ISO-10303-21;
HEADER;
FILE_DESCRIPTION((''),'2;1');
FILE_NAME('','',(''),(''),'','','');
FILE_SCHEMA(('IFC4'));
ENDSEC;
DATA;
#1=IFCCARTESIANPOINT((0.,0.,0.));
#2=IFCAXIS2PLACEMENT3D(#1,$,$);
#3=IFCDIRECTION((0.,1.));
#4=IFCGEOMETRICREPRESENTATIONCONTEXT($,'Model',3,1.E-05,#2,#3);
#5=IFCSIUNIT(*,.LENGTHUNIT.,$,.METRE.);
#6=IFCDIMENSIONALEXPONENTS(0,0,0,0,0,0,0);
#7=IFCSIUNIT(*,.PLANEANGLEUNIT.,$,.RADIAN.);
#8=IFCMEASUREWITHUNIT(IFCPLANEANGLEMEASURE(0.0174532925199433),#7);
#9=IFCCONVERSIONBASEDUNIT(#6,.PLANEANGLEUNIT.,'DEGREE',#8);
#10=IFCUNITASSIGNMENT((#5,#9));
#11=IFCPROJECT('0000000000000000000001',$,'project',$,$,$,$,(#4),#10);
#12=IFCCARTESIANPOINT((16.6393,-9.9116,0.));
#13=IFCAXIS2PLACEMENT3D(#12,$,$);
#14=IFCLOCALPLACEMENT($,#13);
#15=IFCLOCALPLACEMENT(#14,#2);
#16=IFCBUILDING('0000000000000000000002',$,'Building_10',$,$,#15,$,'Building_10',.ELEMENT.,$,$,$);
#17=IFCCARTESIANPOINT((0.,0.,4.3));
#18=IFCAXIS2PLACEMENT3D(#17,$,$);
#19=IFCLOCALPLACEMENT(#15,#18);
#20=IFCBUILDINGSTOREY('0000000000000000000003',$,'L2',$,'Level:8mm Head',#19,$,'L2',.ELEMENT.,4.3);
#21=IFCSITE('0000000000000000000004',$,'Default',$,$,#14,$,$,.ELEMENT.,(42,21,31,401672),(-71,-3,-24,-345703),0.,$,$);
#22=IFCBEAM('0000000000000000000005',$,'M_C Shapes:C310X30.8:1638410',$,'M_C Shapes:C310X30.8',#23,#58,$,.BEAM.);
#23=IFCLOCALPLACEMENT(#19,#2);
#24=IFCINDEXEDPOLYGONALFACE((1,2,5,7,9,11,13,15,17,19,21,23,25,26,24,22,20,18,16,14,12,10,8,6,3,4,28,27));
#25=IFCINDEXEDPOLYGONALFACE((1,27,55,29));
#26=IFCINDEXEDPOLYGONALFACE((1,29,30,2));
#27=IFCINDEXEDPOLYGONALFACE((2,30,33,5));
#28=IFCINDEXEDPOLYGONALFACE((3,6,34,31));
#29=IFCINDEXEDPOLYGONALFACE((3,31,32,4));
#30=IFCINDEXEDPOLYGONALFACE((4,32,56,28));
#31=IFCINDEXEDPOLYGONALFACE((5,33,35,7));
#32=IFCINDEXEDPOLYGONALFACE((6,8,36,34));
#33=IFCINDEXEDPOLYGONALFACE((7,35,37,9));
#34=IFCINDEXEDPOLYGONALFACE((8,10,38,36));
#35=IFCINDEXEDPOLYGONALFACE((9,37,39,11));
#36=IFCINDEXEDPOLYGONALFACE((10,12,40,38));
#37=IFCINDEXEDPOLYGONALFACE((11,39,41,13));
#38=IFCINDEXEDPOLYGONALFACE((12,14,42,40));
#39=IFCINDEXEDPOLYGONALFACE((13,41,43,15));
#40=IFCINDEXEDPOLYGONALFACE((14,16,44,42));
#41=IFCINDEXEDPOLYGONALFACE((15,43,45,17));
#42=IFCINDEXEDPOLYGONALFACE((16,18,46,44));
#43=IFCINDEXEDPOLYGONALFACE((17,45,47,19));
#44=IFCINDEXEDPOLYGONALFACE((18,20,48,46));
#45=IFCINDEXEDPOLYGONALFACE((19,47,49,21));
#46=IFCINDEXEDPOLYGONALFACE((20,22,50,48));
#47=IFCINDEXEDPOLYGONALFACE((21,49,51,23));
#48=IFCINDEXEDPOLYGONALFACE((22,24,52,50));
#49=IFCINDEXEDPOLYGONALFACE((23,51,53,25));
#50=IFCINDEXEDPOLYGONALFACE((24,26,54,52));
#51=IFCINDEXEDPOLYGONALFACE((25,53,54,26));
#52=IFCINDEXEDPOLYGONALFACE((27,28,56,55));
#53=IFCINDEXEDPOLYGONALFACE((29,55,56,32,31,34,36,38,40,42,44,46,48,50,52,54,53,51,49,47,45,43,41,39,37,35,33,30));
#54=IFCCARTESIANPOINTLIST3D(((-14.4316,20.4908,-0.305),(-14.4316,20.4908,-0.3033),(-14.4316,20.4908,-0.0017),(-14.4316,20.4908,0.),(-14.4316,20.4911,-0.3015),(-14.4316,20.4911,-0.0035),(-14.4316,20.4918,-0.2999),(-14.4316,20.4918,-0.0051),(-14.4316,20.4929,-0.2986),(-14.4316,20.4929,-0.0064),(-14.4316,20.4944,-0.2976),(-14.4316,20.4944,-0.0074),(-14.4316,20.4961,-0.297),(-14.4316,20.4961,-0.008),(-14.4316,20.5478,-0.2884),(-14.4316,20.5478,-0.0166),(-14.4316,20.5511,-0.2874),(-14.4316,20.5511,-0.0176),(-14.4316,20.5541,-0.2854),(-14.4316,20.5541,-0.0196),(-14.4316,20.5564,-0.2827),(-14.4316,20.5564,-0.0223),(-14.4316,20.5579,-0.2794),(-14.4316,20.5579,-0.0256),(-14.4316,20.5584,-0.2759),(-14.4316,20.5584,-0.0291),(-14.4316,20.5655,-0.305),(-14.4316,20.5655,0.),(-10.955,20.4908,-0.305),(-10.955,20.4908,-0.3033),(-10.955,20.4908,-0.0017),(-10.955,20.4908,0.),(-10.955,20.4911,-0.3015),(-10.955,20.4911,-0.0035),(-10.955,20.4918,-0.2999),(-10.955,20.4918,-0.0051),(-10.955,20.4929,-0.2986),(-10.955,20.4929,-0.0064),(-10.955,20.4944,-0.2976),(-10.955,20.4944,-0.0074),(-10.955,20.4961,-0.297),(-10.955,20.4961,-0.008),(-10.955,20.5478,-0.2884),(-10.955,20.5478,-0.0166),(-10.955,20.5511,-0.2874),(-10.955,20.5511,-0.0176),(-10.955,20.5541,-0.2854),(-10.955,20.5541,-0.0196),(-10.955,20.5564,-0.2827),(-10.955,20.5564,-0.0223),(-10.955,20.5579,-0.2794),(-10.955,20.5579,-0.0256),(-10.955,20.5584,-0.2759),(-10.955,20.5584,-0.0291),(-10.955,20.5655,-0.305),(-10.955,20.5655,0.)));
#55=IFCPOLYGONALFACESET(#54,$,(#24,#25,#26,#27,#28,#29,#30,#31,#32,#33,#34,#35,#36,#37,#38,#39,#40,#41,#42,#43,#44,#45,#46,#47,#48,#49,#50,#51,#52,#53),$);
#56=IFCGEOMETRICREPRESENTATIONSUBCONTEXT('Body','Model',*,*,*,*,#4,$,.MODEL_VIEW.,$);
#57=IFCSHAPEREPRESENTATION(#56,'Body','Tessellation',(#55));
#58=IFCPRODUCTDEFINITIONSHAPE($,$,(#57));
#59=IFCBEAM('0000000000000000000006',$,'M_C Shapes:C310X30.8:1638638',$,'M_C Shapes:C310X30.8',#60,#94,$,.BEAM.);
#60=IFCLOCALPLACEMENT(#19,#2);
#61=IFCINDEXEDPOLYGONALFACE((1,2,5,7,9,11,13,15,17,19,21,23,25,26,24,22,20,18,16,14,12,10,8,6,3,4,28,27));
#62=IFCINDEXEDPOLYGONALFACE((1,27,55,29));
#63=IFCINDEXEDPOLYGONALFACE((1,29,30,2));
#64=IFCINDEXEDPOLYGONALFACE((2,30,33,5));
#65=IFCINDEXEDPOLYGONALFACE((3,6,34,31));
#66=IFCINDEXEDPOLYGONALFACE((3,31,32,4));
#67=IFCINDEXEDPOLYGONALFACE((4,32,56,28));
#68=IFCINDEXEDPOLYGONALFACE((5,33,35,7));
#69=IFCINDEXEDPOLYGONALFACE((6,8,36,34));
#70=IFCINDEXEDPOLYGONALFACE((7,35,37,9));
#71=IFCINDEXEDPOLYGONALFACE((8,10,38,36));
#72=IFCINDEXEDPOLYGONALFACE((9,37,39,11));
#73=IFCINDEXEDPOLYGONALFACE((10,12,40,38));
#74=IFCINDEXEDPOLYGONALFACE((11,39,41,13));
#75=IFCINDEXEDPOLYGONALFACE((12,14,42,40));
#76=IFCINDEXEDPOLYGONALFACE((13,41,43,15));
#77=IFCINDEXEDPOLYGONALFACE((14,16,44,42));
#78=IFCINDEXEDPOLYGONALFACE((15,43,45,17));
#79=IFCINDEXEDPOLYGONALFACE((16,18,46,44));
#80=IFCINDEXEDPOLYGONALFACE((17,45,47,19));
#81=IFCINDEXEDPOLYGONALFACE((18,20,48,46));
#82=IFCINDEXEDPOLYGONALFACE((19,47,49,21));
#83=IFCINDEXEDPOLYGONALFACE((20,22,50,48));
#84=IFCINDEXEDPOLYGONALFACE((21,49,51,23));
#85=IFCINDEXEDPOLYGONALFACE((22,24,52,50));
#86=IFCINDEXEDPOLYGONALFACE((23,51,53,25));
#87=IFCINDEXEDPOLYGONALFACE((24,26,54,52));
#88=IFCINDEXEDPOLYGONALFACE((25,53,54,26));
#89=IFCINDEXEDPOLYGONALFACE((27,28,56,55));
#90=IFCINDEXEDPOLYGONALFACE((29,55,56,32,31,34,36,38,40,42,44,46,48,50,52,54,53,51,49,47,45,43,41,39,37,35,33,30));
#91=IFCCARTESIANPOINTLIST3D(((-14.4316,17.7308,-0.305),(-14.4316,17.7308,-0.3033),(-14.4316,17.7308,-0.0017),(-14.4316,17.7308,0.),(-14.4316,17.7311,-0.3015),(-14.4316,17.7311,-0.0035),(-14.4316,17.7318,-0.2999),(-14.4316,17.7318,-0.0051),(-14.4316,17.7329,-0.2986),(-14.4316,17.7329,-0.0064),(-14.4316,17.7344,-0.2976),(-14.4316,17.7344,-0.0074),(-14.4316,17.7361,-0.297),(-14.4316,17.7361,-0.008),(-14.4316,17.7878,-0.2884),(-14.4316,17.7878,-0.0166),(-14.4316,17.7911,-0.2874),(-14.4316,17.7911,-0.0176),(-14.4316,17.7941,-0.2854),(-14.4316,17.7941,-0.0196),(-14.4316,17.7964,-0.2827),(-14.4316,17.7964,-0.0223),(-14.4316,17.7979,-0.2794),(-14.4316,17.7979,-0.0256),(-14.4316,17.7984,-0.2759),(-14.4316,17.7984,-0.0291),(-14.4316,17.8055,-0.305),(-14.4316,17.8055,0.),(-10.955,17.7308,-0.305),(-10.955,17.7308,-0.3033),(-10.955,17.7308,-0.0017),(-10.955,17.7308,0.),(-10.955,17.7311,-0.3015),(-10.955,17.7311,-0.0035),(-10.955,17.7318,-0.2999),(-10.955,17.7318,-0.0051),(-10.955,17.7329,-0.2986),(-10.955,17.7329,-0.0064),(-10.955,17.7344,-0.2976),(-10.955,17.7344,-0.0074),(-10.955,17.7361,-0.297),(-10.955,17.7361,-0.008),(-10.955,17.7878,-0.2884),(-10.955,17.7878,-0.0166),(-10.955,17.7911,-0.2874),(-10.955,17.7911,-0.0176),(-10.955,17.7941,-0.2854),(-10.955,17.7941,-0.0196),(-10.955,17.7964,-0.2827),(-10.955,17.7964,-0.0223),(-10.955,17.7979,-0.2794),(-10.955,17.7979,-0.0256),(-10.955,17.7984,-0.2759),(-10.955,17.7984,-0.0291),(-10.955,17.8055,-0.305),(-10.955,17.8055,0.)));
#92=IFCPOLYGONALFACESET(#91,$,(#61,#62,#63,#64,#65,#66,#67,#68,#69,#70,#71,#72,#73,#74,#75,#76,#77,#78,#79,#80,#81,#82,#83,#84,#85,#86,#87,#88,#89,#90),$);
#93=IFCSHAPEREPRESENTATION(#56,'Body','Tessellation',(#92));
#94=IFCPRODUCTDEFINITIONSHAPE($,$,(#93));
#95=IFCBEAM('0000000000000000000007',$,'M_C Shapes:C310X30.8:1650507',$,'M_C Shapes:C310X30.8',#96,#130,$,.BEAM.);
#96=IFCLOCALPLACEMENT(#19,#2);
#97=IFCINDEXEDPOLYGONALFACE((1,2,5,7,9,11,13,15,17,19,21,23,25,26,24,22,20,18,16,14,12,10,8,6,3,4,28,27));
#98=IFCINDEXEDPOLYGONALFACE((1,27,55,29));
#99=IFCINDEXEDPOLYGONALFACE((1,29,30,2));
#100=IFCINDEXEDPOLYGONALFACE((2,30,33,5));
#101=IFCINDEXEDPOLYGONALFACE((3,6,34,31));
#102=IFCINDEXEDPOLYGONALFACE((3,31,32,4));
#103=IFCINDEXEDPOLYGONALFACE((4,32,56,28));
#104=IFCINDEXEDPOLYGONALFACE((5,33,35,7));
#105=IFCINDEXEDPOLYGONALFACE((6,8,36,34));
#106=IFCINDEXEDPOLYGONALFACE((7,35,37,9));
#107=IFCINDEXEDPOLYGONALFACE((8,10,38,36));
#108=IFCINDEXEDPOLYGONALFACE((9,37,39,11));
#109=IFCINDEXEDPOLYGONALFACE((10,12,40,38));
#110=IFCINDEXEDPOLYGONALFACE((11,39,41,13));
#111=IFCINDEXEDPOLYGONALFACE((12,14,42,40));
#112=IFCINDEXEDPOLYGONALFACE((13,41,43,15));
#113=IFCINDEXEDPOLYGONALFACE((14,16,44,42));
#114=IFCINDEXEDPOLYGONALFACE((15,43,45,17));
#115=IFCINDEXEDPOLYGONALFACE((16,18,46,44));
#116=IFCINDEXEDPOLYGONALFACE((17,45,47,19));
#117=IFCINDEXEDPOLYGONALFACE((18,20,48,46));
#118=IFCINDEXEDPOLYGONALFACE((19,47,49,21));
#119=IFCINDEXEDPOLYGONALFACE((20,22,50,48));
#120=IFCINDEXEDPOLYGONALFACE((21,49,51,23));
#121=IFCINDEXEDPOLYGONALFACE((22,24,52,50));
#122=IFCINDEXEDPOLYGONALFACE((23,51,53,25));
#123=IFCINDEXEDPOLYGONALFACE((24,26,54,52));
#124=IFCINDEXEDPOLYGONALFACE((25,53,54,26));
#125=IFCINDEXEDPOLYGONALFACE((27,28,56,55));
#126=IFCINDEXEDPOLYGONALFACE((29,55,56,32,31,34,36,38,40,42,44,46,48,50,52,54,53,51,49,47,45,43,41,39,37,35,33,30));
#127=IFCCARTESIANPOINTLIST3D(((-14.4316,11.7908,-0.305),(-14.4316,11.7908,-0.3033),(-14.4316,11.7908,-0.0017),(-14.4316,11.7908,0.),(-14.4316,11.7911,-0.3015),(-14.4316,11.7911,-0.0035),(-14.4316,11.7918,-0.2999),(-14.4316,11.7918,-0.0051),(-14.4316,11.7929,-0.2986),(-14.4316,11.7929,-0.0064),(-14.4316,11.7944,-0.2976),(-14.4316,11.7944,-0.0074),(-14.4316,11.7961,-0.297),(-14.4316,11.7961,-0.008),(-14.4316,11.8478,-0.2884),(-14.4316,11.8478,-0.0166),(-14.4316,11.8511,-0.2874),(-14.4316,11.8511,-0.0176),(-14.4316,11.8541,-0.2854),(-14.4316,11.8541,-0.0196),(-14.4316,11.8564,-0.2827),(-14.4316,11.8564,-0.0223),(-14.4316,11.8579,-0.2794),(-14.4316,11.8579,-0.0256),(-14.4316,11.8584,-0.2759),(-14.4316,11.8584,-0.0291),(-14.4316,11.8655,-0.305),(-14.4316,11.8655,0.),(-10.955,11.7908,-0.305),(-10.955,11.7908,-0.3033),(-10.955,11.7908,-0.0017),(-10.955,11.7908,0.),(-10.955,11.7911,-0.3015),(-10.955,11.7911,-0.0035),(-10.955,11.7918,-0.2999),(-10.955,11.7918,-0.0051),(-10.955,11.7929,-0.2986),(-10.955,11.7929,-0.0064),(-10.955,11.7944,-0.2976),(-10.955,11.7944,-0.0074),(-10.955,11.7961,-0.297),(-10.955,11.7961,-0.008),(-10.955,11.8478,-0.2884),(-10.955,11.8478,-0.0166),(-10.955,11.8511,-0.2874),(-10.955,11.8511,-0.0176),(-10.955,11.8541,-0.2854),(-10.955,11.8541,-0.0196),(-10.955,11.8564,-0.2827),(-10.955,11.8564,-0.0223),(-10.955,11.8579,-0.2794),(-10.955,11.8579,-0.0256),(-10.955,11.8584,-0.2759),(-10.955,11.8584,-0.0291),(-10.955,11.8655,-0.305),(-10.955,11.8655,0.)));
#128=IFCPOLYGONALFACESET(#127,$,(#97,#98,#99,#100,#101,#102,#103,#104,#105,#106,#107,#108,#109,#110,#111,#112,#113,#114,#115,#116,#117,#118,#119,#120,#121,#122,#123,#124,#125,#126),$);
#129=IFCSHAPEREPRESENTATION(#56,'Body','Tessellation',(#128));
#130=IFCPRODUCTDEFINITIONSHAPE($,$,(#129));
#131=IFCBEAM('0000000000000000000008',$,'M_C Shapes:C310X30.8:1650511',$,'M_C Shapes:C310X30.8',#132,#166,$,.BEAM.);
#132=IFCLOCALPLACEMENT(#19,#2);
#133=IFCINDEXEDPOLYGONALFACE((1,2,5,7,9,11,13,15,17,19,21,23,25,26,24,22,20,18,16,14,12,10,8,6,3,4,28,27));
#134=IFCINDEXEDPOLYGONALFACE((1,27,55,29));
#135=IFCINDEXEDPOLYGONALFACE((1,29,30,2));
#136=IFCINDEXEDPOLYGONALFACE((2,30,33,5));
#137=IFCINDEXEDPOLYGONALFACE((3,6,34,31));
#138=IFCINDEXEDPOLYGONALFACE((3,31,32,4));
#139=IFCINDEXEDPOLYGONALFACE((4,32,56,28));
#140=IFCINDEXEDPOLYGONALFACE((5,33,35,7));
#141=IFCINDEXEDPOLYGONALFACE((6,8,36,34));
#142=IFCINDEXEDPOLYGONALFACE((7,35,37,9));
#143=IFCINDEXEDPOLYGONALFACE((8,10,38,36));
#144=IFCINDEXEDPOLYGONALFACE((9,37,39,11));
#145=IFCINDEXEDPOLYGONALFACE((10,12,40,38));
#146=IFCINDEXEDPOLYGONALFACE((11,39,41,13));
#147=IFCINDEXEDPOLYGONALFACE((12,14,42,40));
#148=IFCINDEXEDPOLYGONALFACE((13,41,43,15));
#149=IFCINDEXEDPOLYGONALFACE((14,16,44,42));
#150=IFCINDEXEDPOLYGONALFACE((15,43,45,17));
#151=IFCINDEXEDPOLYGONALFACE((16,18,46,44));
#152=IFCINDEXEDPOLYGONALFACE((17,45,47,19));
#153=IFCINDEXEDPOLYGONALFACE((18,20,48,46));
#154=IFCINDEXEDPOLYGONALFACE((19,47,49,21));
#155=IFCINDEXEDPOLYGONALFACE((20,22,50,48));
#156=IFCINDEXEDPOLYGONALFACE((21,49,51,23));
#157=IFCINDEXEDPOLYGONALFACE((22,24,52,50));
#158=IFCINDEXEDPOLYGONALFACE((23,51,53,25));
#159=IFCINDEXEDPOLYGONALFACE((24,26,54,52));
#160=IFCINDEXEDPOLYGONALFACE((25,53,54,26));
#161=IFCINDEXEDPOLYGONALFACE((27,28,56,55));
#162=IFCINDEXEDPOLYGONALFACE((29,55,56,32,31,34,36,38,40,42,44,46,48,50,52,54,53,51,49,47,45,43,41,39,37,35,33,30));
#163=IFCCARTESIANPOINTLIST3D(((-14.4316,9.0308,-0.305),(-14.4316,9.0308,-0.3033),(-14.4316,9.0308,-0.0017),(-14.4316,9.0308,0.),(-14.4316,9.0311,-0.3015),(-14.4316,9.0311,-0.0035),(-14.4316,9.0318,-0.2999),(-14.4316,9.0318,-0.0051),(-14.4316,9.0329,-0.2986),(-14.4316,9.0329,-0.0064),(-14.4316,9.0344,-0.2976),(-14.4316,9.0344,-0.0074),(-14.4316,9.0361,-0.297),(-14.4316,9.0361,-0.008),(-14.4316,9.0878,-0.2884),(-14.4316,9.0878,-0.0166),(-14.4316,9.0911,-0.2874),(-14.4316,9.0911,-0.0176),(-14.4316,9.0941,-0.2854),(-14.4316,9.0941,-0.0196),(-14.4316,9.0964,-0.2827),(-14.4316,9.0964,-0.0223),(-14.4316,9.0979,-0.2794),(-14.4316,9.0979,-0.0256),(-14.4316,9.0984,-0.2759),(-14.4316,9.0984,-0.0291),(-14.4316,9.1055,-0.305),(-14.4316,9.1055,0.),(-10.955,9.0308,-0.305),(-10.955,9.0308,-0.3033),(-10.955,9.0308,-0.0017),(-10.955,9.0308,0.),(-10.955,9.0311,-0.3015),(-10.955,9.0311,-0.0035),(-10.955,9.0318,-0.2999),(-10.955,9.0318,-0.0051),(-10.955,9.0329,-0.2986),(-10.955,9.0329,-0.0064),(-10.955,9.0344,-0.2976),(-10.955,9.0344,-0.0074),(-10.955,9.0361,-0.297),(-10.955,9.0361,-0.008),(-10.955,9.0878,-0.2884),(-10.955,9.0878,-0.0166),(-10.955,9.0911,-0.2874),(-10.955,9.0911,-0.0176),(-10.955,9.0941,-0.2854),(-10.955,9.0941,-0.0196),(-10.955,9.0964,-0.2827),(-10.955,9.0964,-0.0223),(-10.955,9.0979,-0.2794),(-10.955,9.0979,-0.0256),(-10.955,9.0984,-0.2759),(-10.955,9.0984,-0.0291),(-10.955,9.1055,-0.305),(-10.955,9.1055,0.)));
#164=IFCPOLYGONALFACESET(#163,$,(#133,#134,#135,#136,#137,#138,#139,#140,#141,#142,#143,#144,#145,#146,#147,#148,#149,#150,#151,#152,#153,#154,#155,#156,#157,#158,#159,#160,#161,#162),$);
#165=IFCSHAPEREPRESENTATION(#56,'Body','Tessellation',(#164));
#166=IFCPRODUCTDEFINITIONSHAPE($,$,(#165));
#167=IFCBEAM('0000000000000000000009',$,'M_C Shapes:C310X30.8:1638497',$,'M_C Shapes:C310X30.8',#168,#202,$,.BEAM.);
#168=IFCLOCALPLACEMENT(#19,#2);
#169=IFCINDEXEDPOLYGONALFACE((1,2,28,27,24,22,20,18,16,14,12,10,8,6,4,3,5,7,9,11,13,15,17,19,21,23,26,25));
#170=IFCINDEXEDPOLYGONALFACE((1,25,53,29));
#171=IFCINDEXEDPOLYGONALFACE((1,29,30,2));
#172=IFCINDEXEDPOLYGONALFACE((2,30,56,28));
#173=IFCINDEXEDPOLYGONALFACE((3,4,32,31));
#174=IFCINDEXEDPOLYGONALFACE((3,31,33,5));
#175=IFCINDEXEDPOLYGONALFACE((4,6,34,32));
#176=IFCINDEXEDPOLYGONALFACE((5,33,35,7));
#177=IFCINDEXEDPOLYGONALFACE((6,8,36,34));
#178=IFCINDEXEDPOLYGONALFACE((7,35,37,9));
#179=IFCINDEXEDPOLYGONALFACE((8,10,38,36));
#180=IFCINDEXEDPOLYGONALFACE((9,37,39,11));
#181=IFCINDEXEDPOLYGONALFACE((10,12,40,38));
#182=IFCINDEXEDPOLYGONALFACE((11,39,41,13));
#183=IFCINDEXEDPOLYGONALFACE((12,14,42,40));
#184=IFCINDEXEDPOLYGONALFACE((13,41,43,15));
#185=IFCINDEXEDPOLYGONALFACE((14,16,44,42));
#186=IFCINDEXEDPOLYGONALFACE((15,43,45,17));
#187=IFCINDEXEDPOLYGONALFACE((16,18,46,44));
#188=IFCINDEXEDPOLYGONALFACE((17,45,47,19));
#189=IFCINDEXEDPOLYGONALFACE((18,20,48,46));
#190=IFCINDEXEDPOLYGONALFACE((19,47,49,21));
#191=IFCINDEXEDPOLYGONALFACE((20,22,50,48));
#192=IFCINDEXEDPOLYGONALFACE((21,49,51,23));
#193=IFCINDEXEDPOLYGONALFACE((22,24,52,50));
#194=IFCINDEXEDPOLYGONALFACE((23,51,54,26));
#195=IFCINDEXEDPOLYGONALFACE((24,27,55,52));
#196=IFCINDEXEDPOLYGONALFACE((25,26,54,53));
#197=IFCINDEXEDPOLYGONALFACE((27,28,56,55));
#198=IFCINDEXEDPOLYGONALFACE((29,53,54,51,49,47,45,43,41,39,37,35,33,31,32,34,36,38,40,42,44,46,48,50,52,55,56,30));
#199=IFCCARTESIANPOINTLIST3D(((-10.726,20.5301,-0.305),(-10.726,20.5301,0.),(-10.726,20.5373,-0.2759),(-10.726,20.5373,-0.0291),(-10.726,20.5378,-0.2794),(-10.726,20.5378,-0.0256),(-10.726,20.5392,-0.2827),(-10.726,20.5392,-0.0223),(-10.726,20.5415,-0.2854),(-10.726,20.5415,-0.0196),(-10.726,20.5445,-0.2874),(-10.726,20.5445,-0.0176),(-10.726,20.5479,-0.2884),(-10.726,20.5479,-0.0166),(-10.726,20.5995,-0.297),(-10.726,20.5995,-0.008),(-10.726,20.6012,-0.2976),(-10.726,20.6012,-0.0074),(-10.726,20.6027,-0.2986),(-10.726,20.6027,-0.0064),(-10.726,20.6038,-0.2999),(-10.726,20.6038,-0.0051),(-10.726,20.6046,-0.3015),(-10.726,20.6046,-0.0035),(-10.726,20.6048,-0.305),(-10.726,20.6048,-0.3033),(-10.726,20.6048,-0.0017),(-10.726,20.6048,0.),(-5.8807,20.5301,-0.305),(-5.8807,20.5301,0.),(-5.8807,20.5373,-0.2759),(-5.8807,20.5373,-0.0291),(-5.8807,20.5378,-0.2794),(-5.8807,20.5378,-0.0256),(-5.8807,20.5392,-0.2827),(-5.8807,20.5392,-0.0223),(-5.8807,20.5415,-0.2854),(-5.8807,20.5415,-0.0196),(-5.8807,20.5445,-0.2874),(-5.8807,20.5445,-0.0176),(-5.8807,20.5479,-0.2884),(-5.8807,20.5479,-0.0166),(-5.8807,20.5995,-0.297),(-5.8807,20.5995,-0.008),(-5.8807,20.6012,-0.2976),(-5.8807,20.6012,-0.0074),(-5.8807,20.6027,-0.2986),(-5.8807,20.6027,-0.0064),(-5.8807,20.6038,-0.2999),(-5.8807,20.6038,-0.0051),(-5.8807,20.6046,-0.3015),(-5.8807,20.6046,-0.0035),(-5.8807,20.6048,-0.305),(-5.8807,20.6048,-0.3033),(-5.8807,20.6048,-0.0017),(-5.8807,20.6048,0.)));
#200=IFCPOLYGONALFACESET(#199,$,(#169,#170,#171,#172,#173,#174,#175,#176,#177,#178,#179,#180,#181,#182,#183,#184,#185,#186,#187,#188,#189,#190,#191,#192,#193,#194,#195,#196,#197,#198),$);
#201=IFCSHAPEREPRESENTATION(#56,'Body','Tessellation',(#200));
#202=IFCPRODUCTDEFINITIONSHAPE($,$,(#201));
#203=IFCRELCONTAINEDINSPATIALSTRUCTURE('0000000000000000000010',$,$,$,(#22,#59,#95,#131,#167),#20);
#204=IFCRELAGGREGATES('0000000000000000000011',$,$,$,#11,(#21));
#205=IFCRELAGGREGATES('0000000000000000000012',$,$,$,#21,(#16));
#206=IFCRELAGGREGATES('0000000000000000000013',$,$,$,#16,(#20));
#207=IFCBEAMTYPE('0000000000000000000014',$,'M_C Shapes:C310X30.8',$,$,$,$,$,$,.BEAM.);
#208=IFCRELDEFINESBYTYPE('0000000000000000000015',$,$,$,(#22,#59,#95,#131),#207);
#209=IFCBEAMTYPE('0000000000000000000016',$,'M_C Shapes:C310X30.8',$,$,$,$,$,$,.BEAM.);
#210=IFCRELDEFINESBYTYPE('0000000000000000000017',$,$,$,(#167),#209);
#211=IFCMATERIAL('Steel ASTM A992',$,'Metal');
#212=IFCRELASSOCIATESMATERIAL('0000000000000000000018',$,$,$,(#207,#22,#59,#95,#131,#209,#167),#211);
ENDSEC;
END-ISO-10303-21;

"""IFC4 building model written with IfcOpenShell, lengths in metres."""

from ifc_helpers import new_model, entity, si_unit, converted_unit, direction, frame, origin, place, context, subcontext, project, spatial, line, arc, indexed_curve, outline, extrude, source, transform, mapped, material, type_object, type_shapes, element, save


model = new_model("IFC4")

# Units and contexts
model_context = context("Model", 3, precision=1e-05, world=origin(), true_north=direction((0.0, 1.0)))
body_context = subcontext(model_context, "Body", "Model", "MODEL_VIEW")
ifc_project = project(units=[si_unit("LENGTHUNIT", "METRE"), converted_unit("PLANEANGLEUNIT", "DEGREE", entity("IfcPlaneAngleMeasure", 0.0174532925199433), si_unit("PLANEANGLEUNIT", "RADIAN"), dimensions=[0, 0, 0, 0, 0, 0, 0])], contexts=[model_context])

# Site, building, storey
site_placement = place(None, frame((16.6393, -9.9116, 0.0)))
site = spatial("IfcSite", under=ifc_project, at=site_placement, Name="Default", CompositionType="ELEMENT", RefLatitude=(42, 21, 31, 401672), RefLongitude=(-71, -3, -24, -345703), RefElevation=0.0)
building_placement = place(site_placement, origin())
building = spatial("IfcBuilding", under=site, at=building_placement, Name="Building_10", LongName="Building_10", CompositionType="ELEMENT")
storey_placement = place(building_placement, frame((0.0, 0.0, 4.3)))
storey = spatial("IfcBuildingStorey", under=building, at=storey_placement, Name="L2", ObjectType="Level:8mm Head", LongName="L2", CompositionType="ELEMENT", Elevation=4.3)

# Shared definitions
ifc_material_1 = material(Name="Steel ASTM A992", Category="Metal")

# Beams
beam_type_1 = type_object("IfcBeamType", Name="M_C Shapes:C310X30.8", PredefinedType="BEAM", material=ifc_material_1)
shared_shape_1 = source(origin(), body_context, "Body", "SweptSolid", [
    extrude(outline(indexed_curve([(-0.0406, -0.1525), (0.0341, -0.1525), (0.0341, -0.1508), (0.0326, -0.1467), (0.0288, -0.1445), (-0.0228, -0.1359), (-0.0305, -0.1316), (-0.0335, -0.1234), (-0.0335, 0.1234), (-0.0305, 0.1316), (-0.0228, 0.1359), (0.0288, 0.1445), (0.0326, 0.1467), (0.0341, 0.1508), (0.0341, 0.1525), (-0.0406, 0.1525)], segments=[line(1, 2, 3), arc(3, 4, 5), line(5, 6), arc(6, 7, 8), line(8, 9), arc(9, 10, 11), line(11, 12), arc(12, 13, 14), line(14, 15, 16, 1)], self_intersect=False)), frame((-1.7383, -0.0229, 0.0), z_axis=(1.0, 0.0, 0.0), x_axis=(0.0, -1.0, 0.0)), (0.0, 0.0, 1.0), 3.4766),
])
type_shapes(beam_type_1, [shared_shape_1])
for number, where, name in (
    (1, (-12.6933, 20.5478, -0.1525), "M_C Shapes:C310X30.8:1638410"),
    (2, (-12.6933, 17.7878, -0.1525), "M_C Shapes:C310X30.8:1638638"),
    (3, (-12.6933, 11.8478, -0.1525), "M_C Shapes:C310X30.8:1650507"),
    (4, (-12.6933, 9.0878, -0.1525), "M_C Shapes:C310X30.8:1650511"),
):
    element("IfcBeam", number, at=place(storey_placement, frame(where)), inside=storey, type_object=beam_type_1, material=ifc_material_1, Name=name, ObjectType="M_C Shapes:C310X30.8", PredefinedType="BEAM", context=body_context, shape_type="MappedRepresentation", body=[
        mapped(shared_shape_1, transform((0.0, 0.0, 0.0), scale=1.0)),
    ])
beam_type_2 = type_object("IfcBeamType", Name="M_C Shapes:C310X30.8", PredefinedType="BEAM", material=ifc_material_1)
shared_shape_2 = source(origin(), body_context, "Body", "SweptSolid", [
    extrude(outline(indexed_curve([(-0.0406, -0.1525), (0.0341, -0.1525), (0.0341, -0.1508), (0.0326, -0.1467), (0.0288, -0.1445), (-0.0228, -0.1359), (-0.0305, -0.1316), (-0.0335, -0.1234), (-0.0335, 0.1234), (-0.0305, 0.1316), (-0.0228, 0.1359), (0.0288, 0.1445), (0.0326, 0.1467), (0.0341, 0.1508), (0.0341, 0.1525), (-0.0406, 0.1525)], segments=[line(1, 2, 3), arc(3, 4, 5), line(5, 6), arc(6, 7, 8), line(8, 9), arc(9, 10, 11), line(11, 12), arc(12, 13, 14), line(14, 15, 16, 1)], self_intersect=False)), frame((-2.4226, -0.0229, 0.0), z_axis=(1.0, 0.0, 0.0), x_axis=(0.0, -1.0, 0.0)), (0.0, 0.0, 1.0), 4.8453),
])
type_shapes(beam_type_2, [shared_shape_2])
beam_1_placement = place(storey_placement, frame((-8.3033, 20.5478, -0.1525), z_axis=(0.0, 0.0, 1.0), x_axis=(-1.0, 0.0, 0.0)))
element("IfcBeam", 5, at=beam_1_placement, inside=storey, type_object=beam_type_2, material=ifc_material_1, Name="M_C Shapes:C310X30.8:1638497", ObjectType="M_C Shapes:C310X30.8", PredefinedType="BEAM", context=body_context, shape_type="MappedRepresentation", body=[
    mapped(shared_shape_2, transform((0.0, 0.0, 0.0), scale=1.0)),
])

save(model, "model.ifc")
